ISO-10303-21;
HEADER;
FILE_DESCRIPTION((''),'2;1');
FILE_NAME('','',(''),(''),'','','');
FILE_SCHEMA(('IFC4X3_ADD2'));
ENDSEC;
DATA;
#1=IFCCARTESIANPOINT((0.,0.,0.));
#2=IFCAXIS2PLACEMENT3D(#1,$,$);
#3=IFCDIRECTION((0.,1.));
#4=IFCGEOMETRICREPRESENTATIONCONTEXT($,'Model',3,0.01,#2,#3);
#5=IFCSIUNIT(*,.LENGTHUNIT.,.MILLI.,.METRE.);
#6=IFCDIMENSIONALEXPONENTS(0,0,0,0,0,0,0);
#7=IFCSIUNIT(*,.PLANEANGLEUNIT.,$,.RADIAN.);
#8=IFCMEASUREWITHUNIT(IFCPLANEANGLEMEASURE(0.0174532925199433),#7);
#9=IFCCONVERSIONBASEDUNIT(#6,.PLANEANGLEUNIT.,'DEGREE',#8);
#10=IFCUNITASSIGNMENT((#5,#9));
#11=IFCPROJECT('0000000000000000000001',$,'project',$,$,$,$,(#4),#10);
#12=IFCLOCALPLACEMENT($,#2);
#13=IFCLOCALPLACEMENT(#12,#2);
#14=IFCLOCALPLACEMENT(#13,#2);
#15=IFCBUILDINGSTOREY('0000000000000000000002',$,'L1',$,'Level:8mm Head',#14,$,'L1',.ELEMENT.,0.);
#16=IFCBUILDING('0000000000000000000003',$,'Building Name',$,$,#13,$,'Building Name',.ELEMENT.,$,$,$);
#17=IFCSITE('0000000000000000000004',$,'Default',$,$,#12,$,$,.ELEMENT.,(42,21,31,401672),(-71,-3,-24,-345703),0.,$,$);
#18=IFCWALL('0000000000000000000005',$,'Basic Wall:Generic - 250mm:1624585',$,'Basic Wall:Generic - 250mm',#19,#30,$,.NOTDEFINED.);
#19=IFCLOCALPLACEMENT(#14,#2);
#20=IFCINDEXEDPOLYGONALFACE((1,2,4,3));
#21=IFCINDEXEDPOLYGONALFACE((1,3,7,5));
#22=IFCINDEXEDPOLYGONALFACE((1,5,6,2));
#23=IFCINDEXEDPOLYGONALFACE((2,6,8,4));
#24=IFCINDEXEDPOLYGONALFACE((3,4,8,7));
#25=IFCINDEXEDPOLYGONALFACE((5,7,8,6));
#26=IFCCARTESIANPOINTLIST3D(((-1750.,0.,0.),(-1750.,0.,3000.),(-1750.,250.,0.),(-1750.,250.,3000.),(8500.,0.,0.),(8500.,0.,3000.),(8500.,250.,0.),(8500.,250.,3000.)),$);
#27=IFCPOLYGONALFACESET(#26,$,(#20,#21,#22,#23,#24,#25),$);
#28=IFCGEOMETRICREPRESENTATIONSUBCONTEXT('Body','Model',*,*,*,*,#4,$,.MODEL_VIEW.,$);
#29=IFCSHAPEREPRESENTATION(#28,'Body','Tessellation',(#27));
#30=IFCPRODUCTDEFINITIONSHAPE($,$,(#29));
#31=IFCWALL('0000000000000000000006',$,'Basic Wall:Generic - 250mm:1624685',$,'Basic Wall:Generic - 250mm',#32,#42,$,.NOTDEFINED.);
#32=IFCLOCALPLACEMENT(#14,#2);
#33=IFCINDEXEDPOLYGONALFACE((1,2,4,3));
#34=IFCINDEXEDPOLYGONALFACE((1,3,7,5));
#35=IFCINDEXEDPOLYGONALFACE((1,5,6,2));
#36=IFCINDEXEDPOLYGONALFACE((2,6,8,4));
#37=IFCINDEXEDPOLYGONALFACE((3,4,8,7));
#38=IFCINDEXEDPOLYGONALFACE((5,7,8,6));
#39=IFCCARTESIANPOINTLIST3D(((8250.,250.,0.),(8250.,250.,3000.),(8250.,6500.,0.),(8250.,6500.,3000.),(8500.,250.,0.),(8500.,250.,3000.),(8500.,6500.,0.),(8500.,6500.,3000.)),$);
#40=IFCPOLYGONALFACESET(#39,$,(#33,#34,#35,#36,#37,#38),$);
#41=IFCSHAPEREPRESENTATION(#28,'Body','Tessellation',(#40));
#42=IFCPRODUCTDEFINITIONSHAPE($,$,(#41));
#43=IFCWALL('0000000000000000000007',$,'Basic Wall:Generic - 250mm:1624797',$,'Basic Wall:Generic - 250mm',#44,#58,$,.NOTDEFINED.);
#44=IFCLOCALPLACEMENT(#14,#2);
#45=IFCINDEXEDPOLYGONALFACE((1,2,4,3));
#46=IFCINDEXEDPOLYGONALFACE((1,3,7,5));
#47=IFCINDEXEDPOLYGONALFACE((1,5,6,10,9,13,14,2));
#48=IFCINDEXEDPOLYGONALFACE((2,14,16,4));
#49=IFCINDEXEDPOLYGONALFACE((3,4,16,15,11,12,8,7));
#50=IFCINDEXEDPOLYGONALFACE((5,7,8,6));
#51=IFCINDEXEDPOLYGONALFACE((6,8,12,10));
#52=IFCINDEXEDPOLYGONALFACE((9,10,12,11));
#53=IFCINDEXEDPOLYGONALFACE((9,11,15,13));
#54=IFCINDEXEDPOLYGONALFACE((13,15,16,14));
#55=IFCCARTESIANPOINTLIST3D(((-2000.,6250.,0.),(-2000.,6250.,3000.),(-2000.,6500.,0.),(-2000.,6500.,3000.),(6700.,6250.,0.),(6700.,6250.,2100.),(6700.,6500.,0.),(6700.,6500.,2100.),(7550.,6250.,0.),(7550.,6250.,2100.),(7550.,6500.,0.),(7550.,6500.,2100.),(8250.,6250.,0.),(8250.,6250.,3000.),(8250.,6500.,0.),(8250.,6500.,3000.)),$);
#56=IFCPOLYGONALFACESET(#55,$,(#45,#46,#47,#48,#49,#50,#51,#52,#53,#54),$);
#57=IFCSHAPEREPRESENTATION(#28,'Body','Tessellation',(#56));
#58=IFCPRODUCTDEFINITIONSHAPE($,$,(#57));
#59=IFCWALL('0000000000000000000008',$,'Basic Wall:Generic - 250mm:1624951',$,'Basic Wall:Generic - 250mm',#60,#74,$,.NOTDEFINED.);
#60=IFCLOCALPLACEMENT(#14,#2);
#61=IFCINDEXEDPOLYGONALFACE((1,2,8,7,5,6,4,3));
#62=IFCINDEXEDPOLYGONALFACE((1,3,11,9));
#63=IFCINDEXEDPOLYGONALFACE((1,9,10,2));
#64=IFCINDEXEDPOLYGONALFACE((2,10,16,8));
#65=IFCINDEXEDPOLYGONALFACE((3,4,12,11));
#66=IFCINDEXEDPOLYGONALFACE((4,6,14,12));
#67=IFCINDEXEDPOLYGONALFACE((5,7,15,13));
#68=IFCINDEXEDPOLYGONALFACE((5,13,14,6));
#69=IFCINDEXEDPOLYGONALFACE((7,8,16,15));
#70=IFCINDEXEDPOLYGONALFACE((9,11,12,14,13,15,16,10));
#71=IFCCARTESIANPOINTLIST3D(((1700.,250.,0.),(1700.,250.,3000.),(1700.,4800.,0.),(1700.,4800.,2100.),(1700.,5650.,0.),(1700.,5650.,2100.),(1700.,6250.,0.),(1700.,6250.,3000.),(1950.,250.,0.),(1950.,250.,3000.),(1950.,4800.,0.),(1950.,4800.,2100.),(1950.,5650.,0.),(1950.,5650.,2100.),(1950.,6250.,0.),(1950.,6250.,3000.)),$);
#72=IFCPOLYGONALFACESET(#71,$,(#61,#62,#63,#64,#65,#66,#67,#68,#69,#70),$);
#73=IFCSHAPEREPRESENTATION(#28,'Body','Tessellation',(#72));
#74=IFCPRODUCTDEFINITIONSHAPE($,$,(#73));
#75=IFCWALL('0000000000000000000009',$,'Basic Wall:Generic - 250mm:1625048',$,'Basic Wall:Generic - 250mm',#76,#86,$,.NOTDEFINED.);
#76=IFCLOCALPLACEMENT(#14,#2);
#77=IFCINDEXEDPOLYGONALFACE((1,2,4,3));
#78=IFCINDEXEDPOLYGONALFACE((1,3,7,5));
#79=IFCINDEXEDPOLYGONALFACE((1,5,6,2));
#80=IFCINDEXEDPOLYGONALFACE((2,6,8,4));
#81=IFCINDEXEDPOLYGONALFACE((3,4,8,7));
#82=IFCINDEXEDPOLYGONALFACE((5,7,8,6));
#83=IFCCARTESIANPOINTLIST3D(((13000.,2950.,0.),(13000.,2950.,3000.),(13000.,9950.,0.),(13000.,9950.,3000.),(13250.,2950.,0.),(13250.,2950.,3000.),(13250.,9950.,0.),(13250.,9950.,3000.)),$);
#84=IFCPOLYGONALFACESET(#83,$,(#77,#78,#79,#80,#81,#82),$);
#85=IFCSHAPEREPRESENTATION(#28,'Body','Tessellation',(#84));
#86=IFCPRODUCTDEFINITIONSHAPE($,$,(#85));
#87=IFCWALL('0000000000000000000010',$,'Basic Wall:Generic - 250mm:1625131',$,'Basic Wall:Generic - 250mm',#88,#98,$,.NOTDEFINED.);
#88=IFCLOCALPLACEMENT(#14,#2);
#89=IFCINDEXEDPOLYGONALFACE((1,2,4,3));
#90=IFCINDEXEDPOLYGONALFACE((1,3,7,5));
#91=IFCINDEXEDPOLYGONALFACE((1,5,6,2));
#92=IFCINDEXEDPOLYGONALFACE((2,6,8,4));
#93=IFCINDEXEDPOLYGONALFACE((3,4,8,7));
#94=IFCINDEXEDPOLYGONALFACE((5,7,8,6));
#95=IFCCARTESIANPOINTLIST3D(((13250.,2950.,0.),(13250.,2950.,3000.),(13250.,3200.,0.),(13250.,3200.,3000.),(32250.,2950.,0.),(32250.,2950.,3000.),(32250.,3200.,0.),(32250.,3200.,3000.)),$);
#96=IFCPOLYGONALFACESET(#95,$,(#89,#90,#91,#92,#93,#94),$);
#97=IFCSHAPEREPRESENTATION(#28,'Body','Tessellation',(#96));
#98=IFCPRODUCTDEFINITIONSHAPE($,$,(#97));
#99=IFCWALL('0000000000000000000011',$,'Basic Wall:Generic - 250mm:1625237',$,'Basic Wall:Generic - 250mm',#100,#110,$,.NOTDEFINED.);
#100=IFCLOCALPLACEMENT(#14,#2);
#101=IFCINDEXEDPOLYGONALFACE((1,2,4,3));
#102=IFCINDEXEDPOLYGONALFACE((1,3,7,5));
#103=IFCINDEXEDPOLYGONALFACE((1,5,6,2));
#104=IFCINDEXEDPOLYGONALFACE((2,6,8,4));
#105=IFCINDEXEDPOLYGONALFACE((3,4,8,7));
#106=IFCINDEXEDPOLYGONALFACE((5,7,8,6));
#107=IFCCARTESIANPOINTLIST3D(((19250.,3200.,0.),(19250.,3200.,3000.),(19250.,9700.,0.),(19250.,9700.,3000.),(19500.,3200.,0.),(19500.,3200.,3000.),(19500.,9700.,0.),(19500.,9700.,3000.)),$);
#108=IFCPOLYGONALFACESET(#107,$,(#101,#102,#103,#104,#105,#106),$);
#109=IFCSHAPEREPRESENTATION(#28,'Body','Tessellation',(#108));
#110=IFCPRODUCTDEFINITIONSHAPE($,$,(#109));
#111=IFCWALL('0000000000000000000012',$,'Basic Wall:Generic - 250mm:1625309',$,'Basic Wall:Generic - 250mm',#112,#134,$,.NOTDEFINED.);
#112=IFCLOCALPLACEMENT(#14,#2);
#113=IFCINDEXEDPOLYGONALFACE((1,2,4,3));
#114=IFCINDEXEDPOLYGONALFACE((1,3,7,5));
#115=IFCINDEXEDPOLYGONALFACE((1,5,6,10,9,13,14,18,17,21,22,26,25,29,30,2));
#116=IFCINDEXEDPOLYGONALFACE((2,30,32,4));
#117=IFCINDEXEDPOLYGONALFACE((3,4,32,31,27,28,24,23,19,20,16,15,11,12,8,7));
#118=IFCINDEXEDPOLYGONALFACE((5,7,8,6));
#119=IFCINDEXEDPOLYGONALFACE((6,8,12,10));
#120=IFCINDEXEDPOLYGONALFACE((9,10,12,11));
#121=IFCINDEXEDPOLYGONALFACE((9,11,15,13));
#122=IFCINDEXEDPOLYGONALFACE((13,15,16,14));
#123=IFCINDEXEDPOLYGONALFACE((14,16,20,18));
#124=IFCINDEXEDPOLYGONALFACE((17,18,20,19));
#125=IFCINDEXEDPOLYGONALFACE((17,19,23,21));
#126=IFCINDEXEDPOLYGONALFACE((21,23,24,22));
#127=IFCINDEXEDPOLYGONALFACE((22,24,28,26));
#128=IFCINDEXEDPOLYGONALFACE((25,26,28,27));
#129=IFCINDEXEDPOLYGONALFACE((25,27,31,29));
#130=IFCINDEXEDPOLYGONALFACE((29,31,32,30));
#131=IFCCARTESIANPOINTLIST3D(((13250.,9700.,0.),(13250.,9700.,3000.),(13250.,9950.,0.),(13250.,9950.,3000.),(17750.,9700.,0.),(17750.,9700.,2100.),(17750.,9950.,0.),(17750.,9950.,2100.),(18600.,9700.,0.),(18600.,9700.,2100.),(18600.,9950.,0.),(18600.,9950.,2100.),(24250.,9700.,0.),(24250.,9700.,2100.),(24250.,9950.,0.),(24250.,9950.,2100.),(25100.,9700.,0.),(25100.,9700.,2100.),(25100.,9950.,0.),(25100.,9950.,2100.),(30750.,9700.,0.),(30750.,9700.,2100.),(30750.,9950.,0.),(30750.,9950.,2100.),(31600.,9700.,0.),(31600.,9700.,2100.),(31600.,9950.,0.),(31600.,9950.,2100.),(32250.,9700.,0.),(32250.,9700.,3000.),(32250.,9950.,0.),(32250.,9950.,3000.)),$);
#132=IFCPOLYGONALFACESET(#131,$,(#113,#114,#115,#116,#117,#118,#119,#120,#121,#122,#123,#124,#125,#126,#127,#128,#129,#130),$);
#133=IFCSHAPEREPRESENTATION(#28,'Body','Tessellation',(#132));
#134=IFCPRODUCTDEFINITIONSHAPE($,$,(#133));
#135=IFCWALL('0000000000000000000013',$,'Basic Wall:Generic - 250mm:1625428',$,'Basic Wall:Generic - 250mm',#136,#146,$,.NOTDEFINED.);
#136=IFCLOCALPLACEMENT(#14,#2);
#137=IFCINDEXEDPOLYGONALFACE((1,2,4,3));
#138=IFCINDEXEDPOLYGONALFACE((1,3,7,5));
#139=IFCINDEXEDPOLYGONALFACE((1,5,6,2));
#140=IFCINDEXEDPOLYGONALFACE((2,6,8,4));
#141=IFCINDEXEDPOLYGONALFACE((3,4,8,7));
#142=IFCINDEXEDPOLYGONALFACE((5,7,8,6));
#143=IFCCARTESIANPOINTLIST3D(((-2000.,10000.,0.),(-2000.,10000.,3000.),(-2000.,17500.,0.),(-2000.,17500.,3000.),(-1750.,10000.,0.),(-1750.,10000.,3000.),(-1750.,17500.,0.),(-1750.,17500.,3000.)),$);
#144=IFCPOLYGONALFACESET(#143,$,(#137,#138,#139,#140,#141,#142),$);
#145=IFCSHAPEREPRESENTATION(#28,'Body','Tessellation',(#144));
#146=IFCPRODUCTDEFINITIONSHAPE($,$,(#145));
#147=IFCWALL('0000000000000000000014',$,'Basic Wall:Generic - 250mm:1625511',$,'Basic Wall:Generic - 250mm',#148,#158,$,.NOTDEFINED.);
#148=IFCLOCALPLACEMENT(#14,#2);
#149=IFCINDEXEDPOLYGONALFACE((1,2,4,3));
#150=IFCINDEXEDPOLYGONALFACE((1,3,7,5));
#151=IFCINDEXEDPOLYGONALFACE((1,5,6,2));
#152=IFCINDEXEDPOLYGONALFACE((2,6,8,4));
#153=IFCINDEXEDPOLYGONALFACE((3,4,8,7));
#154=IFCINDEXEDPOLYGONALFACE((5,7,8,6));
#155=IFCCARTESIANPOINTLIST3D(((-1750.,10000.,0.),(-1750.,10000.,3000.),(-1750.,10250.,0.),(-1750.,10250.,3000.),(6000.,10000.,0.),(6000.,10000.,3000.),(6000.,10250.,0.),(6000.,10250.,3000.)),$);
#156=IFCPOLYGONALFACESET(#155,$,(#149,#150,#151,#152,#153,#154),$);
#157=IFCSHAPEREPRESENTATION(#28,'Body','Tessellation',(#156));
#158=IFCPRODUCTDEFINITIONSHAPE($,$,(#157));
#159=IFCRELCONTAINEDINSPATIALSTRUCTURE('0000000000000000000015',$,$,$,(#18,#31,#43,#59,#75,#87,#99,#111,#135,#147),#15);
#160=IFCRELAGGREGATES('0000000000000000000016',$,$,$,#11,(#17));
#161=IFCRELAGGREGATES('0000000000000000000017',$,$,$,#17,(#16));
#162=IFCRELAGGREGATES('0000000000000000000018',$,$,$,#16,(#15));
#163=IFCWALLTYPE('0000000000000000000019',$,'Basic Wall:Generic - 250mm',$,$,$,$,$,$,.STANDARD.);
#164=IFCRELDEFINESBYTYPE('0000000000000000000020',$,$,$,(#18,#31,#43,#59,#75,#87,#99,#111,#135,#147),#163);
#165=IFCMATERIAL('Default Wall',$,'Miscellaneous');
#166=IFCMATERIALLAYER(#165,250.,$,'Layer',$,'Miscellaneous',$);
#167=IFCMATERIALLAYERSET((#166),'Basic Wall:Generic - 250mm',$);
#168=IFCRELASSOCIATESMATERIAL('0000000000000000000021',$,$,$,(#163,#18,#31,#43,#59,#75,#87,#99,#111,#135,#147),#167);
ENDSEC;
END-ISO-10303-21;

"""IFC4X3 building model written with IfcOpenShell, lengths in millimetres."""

from ifc_helpers import new_model, entity, si_unit, converted_unit, direction, frame, frame_2d, origin, place, context, subcontext, project, spatial, rectangle, extrude, material, layer, layer_set, type_object, element, save


model = new_model("IFC4X3")

# Units and contexts
model_context = context("Model", 3, precision=0.01, world=origin(), true_north=direction((0.0, 1.0)))
body_context = subcontext(model_context, "Body", "Model", "MODEL_VIEW")
ifc_project = project(units=[si_unit("LENGTHUNIT", "METRE", prefix="MILLI"), converted_unit("PLANEANGLEUNIT", "DEGREE", entity("IfcPlaneAngleMeasure", 0.0174532925199433), si_unit("PLANEANGLEUNIT", "RADIAN"), dimensions=[0, 0, 0, 0, 0, 0, 0])], contexts=[model_context])

# Site, building, storey
site_placement = place(None, origin())
site = spatial("IfcSite", under=ifc_project, at=site_placement, Name="Default", CompositionType="ELEMENT", RefLatitude=(42, 21, 31, 401672), RefLongitude=(-71, -3, -24, -345703), RefElevation=0.0)
building_placement = place(site_placement, origin())
building = spatial("IfcBuilding", under=site, at=building_placement, Name="Building Name", LongName="Building Name", CompositionType="ELEMENT")
storey_placement = place(building_placement, origin())
storey = spatial("IfcBuildingStorey", under=building, at=storey_placement, Name="L1", ObjectType="Level:8mm Head", LongName="L1", CompositionType="ELEMENT", Elevation=0.0)

# Walls
ifc_material = material(Name="Default Wall", Category="Miscellaneous")
ifc_layer = layer(ifc_material, 250.0, Name="Layer", Category="Miscellaneous")
ifc_layer_set = layer_set([ifc_layer], Name="Basic Wall:Generic - 250mm")
wall_type = type_object("IfcWallType", Name="Basic Wall:Generic - 250mm", PredefinedType="STANDARD", material=ifc_layer_set)
wall_1_placement = place(storey_placement, frame((-1750.0, 125.0, 0.0)))
element("IfcWall", 1, at=wall_1_placement, inside=storey, type_object=wall_type, material=ifc_layer_set, Name="Basic Wall:Generic - 250mm:1624585", ObjectType="Basic Wall:Generic - 250mm", PredefinedType="NOTDEFINED", context=body_context, shape_type="SweptSolid", body=[
    extrude(rectangle(XDim=10250.0, YDim=250.0, at=frame_2d((5125.0, 0.0), x_axis=(-1.0, 0.0))), origin(), (0.0, 0.0, 1.0), 3000.0),
])
wall_2_placement = place(storey_placement, frame((8375.0, 250.0, 0.0), z_axis=(0.0, 0.0, 1.0), x_axis=(0.0, 1.0, 0.0)))
element("IfcWall", 2, at=wall_2_placement, inside=storey, type_object=wall_type, material=ifc_layer_set, Name="Basic Wall:Generic - 250mm:1624685", ObjectType="Basic Wall:Generic - 250mm", PredefinedType="NOTDEFINED", context=body_context, shape_type="SweptSolid", body=[
    extrude(rectangle(XDim=6250.0, YDim=250.0, at=frame_2d((3125.0, 0.0), x_axis=(-1.0, 0.0))), origin(), (0.0, 0.0, 1.0), 3000.0),
])

# Walls, openings
wall_3_placement = place(storey_placement, frame((8250.0, 6375.0, 0.0), z_axis=(0.0, 0.0, 1.0), x_axis=(-1.0, 0.0, 0.0)))
wall_3 = element("IfcWall", 3, at=wall_3_placement, inside=storey, type_object=wall_type, material=ifc_layer_set, Name="Basic Wall:Generic - 250mm:1624797", ObjectType="Basic Wall:Generic - 250mm", PredefinedType="NOTDEFINED", context=body_context, shape_type="SweptSolid", body=[
    extrude(rectangle(XDim=10250.0, YDim=250.0, at=frame_2d((5125.0, 0.0), x_axis=(1.0, 0.0))), origin(), (0.0, 0.0, 1.0), 3000.0),
])
opening_1_placement = place(wall_3_placement, frame((700.0, -125.0, 0.0)))
element("IfcOpeningElement", 4, at=opening_1_placement, cuts=wall_3, PredefinedType="OPENING", context=body_context, shape_type="SweptSolid", body=[
    extrude(rectangle(XDim=2100.0, YDim=850.0, at=frame_2d((1050.0, 425.0), x_axis=(1.0, 0.0))), frame((0.0, 0.0, 0.0), z_axis=(0.0, 1.0, 0.0), x_axis=(0.0, 0.0, 1.0)), (0.0, 0.0, 1.0), 250.0),
])
wall_4_placement = place(storey_placement, frame((1825.0, 6250.0, 0.0), z_axis=(0.0, 0.0, 1.0), x_axis=(0.0, -1.0, 0.0)))
wall_4 = element("IfcWall", 5, at=wall_4_placement, inside=storey, type_object=wall_type, material=ifc_layer_set, Name="Basic Wall:Generic - 250mm:1624951", ObjectType="Basic Wall:Generic - 250mm", PredefinedType="NOTDEFINED", context=body_context, shape_type="SweptSolid", body=[
    extrude(rectangle(XDim=6000.0, YDim=250.0, at=frame_2d((3000.0, 0.0), x_axis=(1.0, 0.0))), origin(), (0.0, 0.0, 1.0), 3000.0),
])
opening_2_placement = place(wall_4_placement, frame((1450.0, 125.0, 0.0)))
element("IfcOpeningElement", 6, at=opening_2_placement, cuts=wall_4, PredefinedType="OPENING", context=body_context, shape_type="SweptSolid", body=[
    extrude(rectangle(XDim=2100.0, YDim=850.0, at=frame_2d((1050.0, 425.0), x_axis=(1.0, 0.0))), frame((0.0, 0.0, 0.0), z_axis=(0.0, -1.0, 0.0), x_axis=(0.0, 0.0, 1.0)), (0.0, 0.0, 1.0), 250.0),
])

# Walls
wall_5_placement = place(storey_placement, frame((13125.0, 9950.0, 0.0), z_axis=(0.0, 0.0, 1.0), x_axis=(0.0, -1.0, 0.0)))
element("IfcWall", 7, at=wall_5_placement, inside=storey, type_object=wall_type, material=ifc_layer_set, Name="Basic Wall:Generic - 250mm:1625048", ObjectType="Basic Wall:Generic - 250mm", PredefinedType="NOTDEFINED", context=body_context, shape_type="SweptSolid", body=[
    extrude(rectangle(XDim=7000.0, YDim=250.0, at=frame_2d((3500.0, 0.0), x_axis=(-1.0, 0.0))), origin(), (0.0, 0.0, 1.0), 3000.0),
])
wall_6_placement = place(storey_placement, frame((13250.0, 3075.0, 0.0)))
element("IfcWall", 8, at=wall_6_placement, inside=storey, type_object=wall_type, material=ifc_layer_set, Name="Basic Wall:Generic - 250mm:1625131", ObjectType="Basic Wall:Generic - 250mm", PredefinedType="NOTDEFINED", context=body_context, shape_type="SweptSolid", body=[
    extrude(rectangle(XDim=19000.0, YDim=250.0, at=frame_2d((9500.0, 0.0), x_axis=(-1.0, 0.0))), origin(), (0.0, 0.0, 1.0), 3000.0),
])
wall_7_placement = place(storey_placement, frame((19375.0, 3200.0, 0.0), z_axis=(0.0, 0.0, 1.0), x_axis=(0.0, 1.0, 0.0)))
element("IfcWall", 9, at=wall_7_placement, inside=storey, type_object=wall_type, material=ifc_layer_set, Name="Basic Wall:Generic - 250mm:1625237", ObjectType="Basic Wall:Generic - 250mm", PredefinedType="NOTDEFINED", context=body_context, shape_type="SweptSolid", body=[
    extrude(rectangle(XDim=6500.0, YDim=250.0, at=frame_2d((3250.0, 0.0), x_axis=(-1.0, 0.0))), origin(), (0.0, 0.0, 1.0), 3000.0),
])

# Wall, openings
wall_8_placement = place(storey_placement, frame((32250.0, 9825.0, 0.0), z_axis=(0.0, 0.0, 1.0), x_axis=(-1.0, 0.0, 0.0)))
wall_8 = element("IfcWall", 10, at=wall_8_placement, inside=storey, type_object=wall_type, material=ifc_layer_set, Name="Basic Wall:Generic - 250mm:1625309", ObjectType="Basic Wall:Generic - 250mm", PredefinedType="NOTDEFINED", context=body_context, shape_type="SweptSolid", body=[
    extrude(rectangle(XDim=19000.0, YDim=250.0, at=frame_2d((9500.0, 0.0), x_axis=(1.0, 0.0))), origin(), (0.0, 0.0, 1.0), 3000.0),
])
opening_3_placement = place(wall_8_placement, frame((13650.0, -125.0, 0.0)))
element("IfcOpeningElement", 11, at=opening_3_placement, cuts=wall_8, PredefinedType="OPENING", context=body_context, shape_type="SweptSolid", body=[
    extrude(rectangle(XDim=2100.0, YDim=850.0, at=frame_2d((1050.0, 425.0), x_axis=(1.0, 0.0))), frame((0.0, 0.0, 0.0), z_axis=(0.0, 1.0, 0.0), x_axis=(0.0, 0.0, 1.0)), (0.0, 0.0, 1.0), 250.0),
])
opening_4_placement = place(wall_8_placement, frame((7150.0, -125.0, 0.0)))
element("IfcOpeningElement", 12, at=opening_4_placement, cuts=wall_8, PredefinedType="OPENING", context=body_context, shape_type="SweptSolid", body=[
    extrude(rectangle(XDim=2100.0, YDim=850.0, at=frame_2d((1050.0, 425.0), x_axis=(1.0, 0.0))), frame((0.0, 0.0, 0.0), z_axis=(0.0, 1.0, 0.0), x_axis=(0.0, 0.0, 1.0)), (0.0, 0.0, 1.0), 250.0),
])
opening_5_placement = place(wall_8_placement, frame((650.0, -125.0, 0.0)))
element("IfcOpeningElement", 13, at=opening_5_placement, cuts=wall_8, PredefinedType="OPENING", context=body_context, shape_type="SweptSolid", body=[
    extrude(rectangle(XDim=2100.0, YDim=850.0, at=frame_2d((1050.0, 425.0), x_axis=(1.0, 0.0))), frame((0.0, 0.0, 0.0), z_axis=(0.0, 1.0, 0.0), x_axis=(0.0, 0.0, 1.0)), (0.0, 0.0, 1.0), 250.0),
])

# Walls
wall_9_placement = place(storey_placement, frame((-1875.0, 17500.0, 0.0), z_axis=(0.0, 0.0, 1.0), x_axis=(0.0, -1.0, 0.0)))
element("IfcWall", 14, at=wall_9_placement, inside=storey, type_object=wall_type, material=ifc_layer_set, Name="Basic Wall:Generic - 250mm:1625428", ObjectType="Basic Wall:Generic - 250mm", PredefinedType="NOTDEFINED", context=body_context, shape_type="SweptSolid", body=[
    extrude(rectangle(XDim=7500.0, YDim=250.0, at=frame_2d((3750.0, 0.0), x_axis=(-1.0, 0.0))), origin(), (0.0, 0.0, 1.0), 3000.0),
])
wall_10_placement = place(storey_placement, frame((-1750.0, 10125.0, 0.0)))
element("IfcWall", 15, at=wall_10_placement, inside=storey, type_object=wall_type, material=ifc_layer_set, Name="Basic Wall:Generic - 250mm:1625511", ObjectType="Basic Wall:Generic - 250mm", PredefinedType="NOTDEFINED", context=body_context, shape_type="SweptSolid", body=[
    extrude(rectangle(XDim=7750.0, YDim=250.0, at=frame_2d((3875.0, 0.0), x_axis=(-1.0, 0.0))), origin(), (0.0, 0.0, 1.0), 3000.0),
])

save(model, "model.ifc")
